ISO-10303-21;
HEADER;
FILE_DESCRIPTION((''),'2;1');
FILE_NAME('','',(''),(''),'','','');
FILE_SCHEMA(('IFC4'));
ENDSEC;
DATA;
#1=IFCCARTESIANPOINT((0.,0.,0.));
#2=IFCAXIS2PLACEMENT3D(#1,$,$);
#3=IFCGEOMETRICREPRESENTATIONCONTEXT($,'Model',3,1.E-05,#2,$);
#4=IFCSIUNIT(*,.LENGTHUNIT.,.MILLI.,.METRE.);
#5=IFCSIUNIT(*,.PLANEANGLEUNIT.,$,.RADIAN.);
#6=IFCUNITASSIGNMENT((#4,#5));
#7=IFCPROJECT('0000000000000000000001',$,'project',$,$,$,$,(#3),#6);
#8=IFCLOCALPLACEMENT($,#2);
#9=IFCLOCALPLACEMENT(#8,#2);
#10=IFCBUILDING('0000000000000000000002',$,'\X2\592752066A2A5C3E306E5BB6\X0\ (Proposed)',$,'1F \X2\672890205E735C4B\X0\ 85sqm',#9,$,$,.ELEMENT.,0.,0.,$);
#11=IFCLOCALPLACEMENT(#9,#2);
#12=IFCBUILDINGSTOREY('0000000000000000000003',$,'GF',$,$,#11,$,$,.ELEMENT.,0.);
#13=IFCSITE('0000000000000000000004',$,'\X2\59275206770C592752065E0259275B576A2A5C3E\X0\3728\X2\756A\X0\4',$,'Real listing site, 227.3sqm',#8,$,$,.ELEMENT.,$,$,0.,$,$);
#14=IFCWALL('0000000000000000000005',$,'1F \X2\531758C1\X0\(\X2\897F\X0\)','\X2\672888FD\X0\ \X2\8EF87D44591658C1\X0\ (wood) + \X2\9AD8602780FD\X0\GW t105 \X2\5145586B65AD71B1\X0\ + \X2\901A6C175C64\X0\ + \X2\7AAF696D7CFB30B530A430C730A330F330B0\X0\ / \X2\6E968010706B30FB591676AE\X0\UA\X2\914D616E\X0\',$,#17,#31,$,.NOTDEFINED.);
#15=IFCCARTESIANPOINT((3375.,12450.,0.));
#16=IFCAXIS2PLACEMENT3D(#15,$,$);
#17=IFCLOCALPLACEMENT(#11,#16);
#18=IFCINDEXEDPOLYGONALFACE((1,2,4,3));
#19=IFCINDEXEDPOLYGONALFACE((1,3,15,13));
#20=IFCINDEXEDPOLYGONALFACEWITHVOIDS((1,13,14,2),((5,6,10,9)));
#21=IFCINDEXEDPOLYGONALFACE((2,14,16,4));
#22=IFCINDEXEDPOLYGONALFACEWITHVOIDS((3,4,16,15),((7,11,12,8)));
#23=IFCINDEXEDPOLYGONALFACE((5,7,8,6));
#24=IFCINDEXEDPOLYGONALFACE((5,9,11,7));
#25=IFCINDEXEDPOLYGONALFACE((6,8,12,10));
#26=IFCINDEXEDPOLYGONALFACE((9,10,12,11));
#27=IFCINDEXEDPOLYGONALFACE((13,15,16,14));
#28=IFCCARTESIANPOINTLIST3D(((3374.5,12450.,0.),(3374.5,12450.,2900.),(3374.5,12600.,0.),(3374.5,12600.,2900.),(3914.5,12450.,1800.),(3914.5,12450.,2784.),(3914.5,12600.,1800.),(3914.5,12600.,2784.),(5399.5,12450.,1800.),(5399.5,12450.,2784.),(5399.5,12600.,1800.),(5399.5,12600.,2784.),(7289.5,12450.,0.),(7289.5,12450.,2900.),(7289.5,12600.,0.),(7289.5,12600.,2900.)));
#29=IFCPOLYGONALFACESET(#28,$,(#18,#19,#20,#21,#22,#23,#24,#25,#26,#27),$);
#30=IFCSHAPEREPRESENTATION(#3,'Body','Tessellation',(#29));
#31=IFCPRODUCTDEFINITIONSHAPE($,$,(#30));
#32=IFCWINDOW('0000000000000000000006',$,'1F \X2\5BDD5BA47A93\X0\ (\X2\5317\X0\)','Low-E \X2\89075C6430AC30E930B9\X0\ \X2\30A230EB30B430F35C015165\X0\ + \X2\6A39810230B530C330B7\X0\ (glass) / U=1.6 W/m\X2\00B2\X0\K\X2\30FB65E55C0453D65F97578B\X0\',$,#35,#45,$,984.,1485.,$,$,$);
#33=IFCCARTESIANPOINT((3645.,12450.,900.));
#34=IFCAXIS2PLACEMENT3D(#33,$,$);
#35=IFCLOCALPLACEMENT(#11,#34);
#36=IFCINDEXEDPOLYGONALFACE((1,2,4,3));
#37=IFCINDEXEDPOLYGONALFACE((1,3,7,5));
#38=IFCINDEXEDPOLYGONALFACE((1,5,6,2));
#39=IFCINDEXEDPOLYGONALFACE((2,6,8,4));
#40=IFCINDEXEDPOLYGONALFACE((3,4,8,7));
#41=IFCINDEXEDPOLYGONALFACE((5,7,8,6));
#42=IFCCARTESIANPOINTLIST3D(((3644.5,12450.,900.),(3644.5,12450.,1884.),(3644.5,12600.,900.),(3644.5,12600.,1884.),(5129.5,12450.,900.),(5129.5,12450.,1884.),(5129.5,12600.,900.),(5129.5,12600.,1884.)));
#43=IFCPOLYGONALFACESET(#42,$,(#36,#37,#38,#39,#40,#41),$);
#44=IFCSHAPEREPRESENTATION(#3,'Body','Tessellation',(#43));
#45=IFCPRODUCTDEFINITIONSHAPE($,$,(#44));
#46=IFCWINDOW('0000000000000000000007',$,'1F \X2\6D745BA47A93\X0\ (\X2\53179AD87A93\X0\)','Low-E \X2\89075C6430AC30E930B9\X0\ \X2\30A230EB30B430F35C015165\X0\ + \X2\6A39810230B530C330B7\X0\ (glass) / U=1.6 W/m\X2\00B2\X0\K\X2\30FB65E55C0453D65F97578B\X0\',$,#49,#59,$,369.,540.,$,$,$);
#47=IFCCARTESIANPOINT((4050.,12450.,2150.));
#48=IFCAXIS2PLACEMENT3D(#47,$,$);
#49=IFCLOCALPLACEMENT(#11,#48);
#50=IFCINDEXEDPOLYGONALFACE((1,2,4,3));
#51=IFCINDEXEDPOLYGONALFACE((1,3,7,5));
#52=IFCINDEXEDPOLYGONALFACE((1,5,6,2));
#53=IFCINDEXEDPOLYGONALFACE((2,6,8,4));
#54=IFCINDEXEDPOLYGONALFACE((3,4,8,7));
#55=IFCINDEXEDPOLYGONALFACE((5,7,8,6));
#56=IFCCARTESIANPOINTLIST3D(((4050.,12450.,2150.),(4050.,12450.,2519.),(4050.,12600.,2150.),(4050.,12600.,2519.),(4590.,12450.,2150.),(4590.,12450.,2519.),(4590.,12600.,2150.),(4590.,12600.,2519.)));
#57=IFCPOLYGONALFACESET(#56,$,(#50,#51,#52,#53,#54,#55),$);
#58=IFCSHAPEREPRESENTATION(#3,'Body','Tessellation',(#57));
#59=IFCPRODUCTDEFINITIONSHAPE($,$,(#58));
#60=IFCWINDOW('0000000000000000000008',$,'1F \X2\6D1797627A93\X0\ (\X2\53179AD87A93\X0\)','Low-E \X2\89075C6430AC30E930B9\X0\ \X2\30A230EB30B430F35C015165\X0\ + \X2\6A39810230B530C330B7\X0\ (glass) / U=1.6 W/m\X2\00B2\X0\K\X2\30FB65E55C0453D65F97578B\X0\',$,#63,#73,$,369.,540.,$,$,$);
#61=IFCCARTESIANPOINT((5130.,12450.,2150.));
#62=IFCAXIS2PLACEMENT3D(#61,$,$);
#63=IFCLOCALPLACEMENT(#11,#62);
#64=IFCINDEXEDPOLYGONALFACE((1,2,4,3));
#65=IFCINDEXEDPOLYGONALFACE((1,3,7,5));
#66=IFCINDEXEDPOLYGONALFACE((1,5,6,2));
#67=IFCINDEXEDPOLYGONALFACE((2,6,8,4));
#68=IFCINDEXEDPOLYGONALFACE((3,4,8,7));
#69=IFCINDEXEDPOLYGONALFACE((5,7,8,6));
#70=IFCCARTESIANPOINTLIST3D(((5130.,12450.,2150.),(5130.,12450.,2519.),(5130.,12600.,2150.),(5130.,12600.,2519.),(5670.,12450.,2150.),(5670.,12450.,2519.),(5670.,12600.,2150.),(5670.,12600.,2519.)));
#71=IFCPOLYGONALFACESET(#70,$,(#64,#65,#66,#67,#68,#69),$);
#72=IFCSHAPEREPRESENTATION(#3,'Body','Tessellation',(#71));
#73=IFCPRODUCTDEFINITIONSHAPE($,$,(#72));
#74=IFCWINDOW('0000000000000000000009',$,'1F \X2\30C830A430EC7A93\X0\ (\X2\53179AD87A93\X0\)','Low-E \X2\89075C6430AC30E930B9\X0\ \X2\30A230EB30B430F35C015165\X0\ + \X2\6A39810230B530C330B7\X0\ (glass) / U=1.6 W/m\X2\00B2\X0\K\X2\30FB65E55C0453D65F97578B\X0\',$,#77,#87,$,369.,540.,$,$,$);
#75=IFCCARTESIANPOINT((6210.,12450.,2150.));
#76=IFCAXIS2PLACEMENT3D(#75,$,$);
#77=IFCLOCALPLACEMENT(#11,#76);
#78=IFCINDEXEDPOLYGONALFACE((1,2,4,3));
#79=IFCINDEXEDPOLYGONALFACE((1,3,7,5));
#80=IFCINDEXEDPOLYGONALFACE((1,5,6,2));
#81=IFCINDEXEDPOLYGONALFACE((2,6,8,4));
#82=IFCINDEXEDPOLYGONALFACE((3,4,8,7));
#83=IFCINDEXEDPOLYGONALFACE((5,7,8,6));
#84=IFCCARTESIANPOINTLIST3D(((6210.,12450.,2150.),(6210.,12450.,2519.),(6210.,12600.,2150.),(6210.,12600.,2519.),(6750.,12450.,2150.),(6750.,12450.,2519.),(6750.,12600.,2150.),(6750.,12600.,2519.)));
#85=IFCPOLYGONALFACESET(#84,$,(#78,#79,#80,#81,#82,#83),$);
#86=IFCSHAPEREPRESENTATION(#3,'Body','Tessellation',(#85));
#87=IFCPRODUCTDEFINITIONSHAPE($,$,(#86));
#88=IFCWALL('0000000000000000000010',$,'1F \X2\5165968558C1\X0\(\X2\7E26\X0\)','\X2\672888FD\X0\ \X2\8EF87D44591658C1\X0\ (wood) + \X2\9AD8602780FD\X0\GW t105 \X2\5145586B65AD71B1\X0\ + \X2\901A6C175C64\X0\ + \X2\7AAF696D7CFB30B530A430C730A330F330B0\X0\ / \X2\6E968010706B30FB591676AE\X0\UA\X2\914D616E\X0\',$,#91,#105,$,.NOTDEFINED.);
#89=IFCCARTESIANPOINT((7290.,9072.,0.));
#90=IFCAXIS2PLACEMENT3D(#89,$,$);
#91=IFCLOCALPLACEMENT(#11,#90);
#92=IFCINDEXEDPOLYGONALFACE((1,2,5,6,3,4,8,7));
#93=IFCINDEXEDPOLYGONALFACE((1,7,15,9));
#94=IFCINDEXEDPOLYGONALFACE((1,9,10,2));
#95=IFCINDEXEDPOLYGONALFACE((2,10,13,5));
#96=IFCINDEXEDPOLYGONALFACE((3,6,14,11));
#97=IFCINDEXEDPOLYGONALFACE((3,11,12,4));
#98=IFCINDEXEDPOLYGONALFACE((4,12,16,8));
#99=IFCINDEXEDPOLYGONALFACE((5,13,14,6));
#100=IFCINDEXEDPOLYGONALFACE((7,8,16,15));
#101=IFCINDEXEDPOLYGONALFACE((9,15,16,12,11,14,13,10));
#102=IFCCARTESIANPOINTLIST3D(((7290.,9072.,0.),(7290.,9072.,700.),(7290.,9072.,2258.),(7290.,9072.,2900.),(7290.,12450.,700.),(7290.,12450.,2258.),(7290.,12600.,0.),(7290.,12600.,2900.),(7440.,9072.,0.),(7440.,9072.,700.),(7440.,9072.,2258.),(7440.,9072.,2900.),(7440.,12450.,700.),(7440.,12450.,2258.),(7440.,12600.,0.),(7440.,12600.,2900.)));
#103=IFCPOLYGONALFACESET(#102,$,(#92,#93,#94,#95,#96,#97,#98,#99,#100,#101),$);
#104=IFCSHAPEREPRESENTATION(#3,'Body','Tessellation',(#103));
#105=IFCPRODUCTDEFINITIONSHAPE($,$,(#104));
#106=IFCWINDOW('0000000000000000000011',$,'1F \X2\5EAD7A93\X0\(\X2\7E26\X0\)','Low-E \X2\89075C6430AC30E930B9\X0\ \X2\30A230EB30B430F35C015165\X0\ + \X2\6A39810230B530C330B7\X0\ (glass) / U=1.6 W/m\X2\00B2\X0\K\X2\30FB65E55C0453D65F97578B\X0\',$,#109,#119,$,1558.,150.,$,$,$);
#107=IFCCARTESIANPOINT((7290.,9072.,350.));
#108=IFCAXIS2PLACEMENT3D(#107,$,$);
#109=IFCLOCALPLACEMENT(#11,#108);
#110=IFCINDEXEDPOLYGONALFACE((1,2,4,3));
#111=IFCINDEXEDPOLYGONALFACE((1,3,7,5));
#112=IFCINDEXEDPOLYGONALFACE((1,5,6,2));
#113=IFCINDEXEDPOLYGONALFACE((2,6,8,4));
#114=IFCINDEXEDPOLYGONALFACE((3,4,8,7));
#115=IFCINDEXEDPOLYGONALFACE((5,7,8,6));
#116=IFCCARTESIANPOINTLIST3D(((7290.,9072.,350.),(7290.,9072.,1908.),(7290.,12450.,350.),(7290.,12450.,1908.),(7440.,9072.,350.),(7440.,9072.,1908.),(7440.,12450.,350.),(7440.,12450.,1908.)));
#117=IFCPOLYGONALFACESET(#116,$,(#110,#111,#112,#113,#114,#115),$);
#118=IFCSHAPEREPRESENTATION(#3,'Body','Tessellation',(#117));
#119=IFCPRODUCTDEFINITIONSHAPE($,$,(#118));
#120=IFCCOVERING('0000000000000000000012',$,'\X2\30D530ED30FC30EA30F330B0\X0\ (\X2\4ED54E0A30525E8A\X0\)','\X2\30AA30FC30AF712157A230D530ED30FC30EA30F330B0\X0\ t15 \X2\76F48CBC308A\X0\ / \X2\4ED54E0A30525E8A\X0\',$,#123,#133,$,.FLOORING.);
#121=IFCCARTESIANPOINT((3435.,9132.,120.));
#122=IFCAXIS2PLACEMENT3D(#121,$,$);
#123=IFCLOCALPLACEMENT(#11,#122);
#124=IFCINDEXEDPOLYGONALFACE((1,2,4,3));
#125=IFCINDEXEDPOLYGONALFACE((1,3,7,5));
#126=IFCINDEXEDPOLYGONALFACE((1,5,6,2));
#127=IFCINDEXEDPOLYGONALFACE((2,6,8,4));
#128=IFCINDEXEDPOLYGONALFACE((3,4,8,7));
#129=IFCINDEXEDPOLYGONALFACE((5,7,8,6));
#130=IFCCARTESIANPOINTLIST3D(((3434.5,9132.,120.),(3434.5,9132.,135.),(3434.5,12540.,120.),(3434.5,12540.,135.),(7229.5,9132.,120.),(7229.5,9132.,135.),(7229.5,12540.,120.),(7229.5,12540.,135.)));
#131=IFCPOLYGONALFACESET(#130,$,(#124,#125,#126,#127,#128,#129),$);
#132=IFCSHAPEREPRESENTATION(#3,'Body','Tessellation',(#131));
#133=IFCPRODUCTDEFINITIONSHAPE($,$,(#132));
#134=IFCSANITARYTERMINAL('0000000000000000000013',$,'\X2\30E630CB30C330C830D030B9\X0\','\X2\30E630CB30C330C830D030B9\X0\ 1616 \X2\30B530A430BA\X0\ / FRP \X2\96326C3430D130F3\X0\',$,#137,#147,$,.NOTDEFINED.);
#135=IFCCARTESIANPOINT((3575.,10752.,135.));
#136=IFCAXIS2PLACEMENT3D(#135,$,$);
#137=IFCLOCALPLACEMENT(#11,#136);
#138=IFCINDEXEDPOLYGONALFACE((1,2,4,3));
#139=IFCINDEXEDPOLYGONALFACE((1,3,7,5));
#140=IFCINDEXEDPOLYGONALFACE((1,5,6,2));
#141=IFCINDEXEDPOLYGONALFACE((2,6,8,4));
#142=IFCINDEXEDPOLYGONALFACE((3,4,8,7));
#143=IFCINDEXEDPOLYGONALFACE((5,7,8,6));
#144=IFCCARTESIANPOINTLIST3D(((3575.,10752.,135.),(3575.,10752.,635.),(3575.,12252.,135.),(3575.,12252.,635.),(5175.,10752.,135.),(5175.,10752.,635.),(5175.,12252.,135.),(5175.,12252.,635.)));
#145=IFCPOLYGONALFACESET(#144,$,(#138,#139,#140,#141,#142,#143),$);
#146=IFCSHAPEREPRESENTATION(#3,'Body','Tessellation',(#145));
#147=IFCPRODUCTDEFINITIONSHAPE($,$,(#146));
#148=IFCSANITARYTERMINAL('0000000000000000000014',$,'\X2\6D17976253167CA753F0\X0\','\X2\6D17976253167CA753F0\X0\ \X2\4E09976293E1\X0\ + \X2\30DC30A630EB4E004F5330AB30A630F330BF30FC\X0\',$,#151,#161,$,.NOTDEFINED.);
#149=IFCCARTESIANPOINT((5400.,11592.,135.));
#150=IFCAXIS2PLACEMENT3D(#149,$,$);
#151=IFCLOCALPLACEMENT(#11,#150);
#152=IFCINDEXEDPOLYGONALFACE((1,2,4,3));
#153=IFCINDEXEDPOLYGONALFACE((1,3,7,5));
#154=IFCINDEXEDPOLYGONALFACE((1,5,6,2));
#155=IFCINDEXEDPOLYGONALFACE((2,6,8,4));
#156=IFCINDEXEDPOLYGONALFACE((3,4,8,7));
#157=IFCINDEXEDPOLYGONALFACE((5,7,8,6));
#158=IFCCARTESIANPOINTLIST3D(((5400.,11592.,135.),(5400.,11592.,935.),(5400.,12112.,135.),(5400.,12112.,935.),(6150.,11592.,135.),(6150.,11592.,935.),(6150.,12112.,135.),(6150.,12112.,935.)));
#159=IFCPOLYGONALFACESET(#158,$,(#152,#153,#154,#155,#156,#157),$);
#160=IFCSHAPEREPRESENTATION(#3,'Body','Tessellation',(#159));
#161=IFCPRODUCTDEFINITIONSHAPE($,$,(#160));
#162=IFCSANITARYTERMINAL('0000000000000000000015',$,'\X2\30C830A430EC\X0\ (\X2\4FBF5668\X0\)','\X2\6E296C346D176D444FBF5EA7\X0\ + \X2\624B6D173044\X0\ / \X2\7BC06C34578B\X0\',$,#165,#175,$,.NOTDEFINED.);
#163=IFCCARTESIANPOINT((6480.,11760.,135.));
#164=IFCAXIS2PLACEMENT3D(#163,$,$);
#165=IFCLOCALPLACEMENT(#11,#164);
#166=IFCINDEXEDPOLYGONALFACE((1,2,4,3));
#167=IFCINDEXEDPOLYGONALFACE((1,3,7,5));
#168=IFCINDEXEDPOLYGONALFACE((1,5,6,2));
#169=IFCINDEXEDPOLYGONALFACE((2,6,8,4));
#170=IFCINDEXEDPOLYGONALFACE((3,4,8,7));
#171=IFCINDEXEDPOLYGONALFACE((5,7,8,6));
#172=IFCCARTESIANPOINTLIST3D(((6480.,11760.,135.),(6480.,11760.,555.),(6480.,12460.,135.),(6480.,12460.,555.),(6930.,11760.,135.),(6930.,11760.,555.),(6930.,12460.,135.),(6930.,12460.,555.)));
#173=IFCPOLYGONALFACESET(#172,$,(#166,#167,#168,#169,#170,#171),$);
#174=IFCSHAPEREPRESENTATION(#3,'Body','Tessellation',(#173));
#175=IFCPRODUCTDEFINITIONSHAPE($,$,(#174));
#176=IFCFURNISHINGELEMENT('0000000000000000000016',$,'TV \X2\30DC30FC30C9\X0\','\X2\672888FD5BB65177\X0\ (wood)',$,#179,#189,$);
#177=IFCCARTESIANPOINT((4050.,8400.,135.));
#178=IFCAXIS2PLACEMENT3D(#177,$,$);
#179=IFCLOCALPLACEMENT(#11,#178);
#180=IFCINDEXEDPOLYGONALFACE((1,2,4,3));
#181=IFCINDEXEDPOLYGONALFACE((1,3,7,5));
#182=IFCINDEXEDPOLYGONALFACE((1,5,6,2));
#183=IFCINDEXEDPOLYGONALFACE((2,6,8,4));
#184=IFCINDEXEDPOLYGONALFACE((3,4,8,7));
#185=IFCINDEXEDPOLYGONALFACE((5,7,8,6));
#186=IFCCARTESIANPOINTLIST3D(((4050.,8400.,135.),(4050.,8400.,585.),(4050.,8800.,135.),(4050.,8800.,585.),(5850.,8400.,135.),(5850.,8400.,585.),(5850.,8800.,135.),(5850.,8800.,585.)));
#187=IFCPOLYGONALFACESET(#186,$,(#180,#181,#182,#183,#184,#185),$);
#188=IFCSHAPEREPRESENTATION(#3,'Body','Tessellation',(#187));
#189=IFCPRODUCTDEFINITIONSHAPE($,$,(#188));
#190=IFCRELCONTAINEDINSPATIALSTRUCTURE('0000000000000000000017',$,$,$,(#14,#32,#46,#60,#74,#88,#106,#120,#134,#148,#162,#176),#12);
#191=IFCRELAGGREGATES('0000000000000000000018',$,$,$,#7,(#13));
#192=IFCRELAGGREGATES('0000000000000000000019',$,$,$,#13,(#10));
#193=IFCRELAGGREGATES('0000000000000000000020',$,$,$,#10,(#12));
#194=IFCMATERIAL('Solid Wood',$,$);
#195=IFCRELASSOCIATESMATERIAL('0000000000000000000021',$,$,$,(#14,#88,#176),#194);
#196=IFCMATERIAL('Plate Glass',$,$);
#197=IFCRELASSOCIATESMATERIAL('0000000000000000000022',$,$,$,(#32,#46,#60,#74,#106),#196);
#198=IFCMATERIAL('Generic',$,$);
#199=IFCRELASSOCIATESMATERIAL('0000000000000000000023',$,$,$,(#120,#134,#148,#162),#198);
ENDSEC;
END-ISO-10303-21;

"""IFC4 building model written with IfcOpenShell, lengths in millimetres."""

from ifc_helpers import new_model, si_unit, frame, frame_2d, origin, place, context, project, spatial, rectangle, extrude, material, element, fill, save


model = new_model("IFC4")

# Units and contexts
model_context = context("Model", 3, precision=1e-05, world=origin())
ifc_project = project(units=[si_unit("LENGTHUNIT", "METRE", prefix="MILLI"), si_unit("PLANEANGLEUNIT", "RADIAN")], contexts=[model_context])

# Site, building, storey
site_placement = place(None, origin())
site = spatial("IfcSite", under=ifc_project, at=site_placement, Name="大分県大分市大字横尾3728番4", ObjectType="Real listing site, 227.3sqm", CompositionType="ELEMENT", RefElevation=0.0)
building_placement = place(site_placement, origin())
building = spatial("IfcBuilding", under=site, at=building_placement, Name="大分横尾の家 (Proposed)", ObjectType="1F 木造平屋 85sqm", CompositionType="ELEMENT", ElevationOfRefHeight=0.0, ElevationOfTerrain=0.0)
storey_placement = place(building_placement, origin())
storey = spatial("IfcBuildingStorey", under=building, at=storey_placement, Name="GF", CompositionType="ELEMENT", Elevation=0.0)

# Shared definitions
ifc_material_1 = material(Name="Solid Wood")

# Wall, openings, windows
wall_1_placement = place(storey_placement, frame((3375.0, 12450.0, 0.0)))
wall_1 = element("IfcWall", 1, at=wall_1_placement, inside=storey, material=ifc_material_1, Name="1F 北壁(西)", Description="木製 軸組外壁 (wood) + 高性能GW t105 充填断熱 + 通気層 + 窯業系サイディング / 準耐火・外皮UA配慮", PredefinedType="NOTDEFINED", context=model_context, shape_type="SweptSolid", body=[
    extrude(rectangle(XDim=3915.0, YDim=150.0, at=frame_2d((1957.0, 75.0))), frame((3375.0, 12450.0, 0.0)), (0.0, 0.0, 1.0), 2900.0),
])
opening_1_placement = place(storey_placement, frame((3645.0, 12450.0, 900.0)))
opening_1 = element("IfcOpeningElement", 2, at=opening_1_placement, cuts=wall_1, PredefinedType="NOTDEFINED", context=model_context, shape_type="SweptSolid", body=[
    extrude(rectangle(XDim=1485.0, YDim=150.0, at=frame_2d((742.0, 75.0))), frame((3645.0, 12450.0, 900.0)), (0.0, 0.0, 1.0), 984.0),
])
opening_2_placement = place(storey_placement, frame((4050.0, 12450.0, 2150.0)))
opening_2 = element("IfcOpeningElement", 3, at=opening_2_placement, cuts=wall_1, PredefinedType="NOTDEFINED", context=model_context, shape_type="SweptSolid", body=[
    extrude(rectangle(XDim=540.0, YDim=150.0, at=frame_2d((270.0, 75.0))), frame((4050.0, 12450.0, 2150.0)), (0.0, 0.0, 1.0), 369.0),
])
opening_3_placement = place(storey_placement, frame((5130.0, 12450.0, 2150.0)))
opening_3 = element("IfcOpeningElement", 4, at=opening_3_placement, cuts=wall_1, PredefinedType="NOTDEFINED", context=model_context, shape_type="SweptSolid", body=[
    extrude(rectangle(XDim=540.0, YDim=150.0, at=frame_2d((270.0, 75.0))), frame((5130.0, 12450.0, 2150.0)), (0.0, 0.0, 1.0), 369.0),
])
opening_4_placement = place(storey_placement, frame((6210.0, 12450.0, 2150.0)))
opening_4 = element("IfcOpeningElement", 5, at=opening_4_placement, cuts=wall_1, PredefinedType="NOTDEFINED", context=model_context, shape_type="SweptSolid", body=[
    extrude(rectangle(XDim=540.0, YDim=150.0, at=frame_2d((270.0, 75.0))), frame((6210.0, 12450.0, 2150.0)), (0.0, 0.0, 1.0), 369.0),
])
ifc_material_2 = material(Name="Plate Glass")
window_1_placement = place(storey_placement, frame((3645.0, 12450.0, 900.0)))
window_1 = element("IfcWindow", 6, at=window_1_placement, inside=storey, material=ifc_material_2, Name="1F 寝室窓 (北)", Description="Low-E 複層ガラス アルゴン封入 + 樹脂サッシ (glass) / U=1.6 W/m²K・日射取得型", OverallHeight=984.0, OverallWidth=1485.0, context=model_context, shape_type="SweptSolid", body=[
    extrude(rectangle(XDim=1485.0, YDim=150.0, at=frame_2d((742.0, 75.0))), frame((3645.0, 12450.0, 900.0)), (0.0, 0.0, 1.0), 984.0),
])
fill(opening_1, window_1)
window_2_placement = place(storey_placement, frame((4050.0, 12450.0, 2150.0)))
window_2 = element("IfcWindow", 7, at=window_2_placement, inside=storey, material=ifc_material_2, Name="1F 浴室窓 (北高窓)", Description="Low-E 複層ガラス アルゴン封入 + 樹脂サッシ (glass) / U=1.6 W/m²K・日射取得型", OverallHeight=369.0, OverallWidth=540.0, context=model_context, shape_type="SweptSolid", body=[
    extrude(rectangle(XDim=540.0, YDim=150.0, at=frame_2d((270.0, 75.0))), frame((4050.0, 12450.0, 2150.0)), (0.0, 0.0, 1.0), 369.0),
])
fill(opening_2, window_2)
window_3_placement = place(storey_placement, frame((5130.0, 12450.0, 2150.0)))
window_3 = element("IfcWindow", 8, at=window_3_placement, inside=storey, material=ifc_material_2, Name="1F 洗面窓 (北高窓)", Description="Low-E 複層ガラス アルゴン封入 + 樹脂サッシ (glass) / U=1.6 W/m²K・日射取得型", OverallHeight=369.0, OverallWidth=540.0, context=model_context, shape_type="SweptSolid", body=[
    extrude(rectangle(XDim=540.0, YDim=150.0, at=frame_2d((270.0, 75.0))), frame((5130.0, 12450.0, 2150.0)), (0.0, 0.0, 1.0), 369.0),
])
fill(opening_3, window_3)
window_4_placement = place(storey_placement, frame((6210.0, 12450.0, 2150.0)))
window_4 = element("IfcWindow", 9, at=window_4_placement, inside=storey, material=ifc_material_2, Name="1F トイレ窓 (北高窓)", Description="Low-E 複層ガラス アルゴン封入 + 樹脂サッシ (glass) / U=1.6 W/m²K・日射取得型", OverallHeight=369.0, OverallWidth=540.0, context=model_context, shape_type="SweptSolid", body=[
    extrude(rectangle(XDim=540.0, YDim=150.0, at=frame_2d((270.0, 75.0))), frame((6210.0, 12450.0, 2150.0)), (0.0, 0.0, 1.0), 369.0),
])
fill(opening_4, window_4)

# Wall, opening, window
wall_2_placement = place(storey_placement, frame((7290.0, 9072.0, 0.0)))
wall_2 = element("IfcWall", 10, at=wall_2_placement, inside=storey, material=ifc_material_1, Name="1F 入隅壁(縦)", Description="木製 軸組外壁 (wood) + 高性能GW t105 充填断熱 + 通気層 + 窯業系サイディング / 準耐火・外皮UA配慮", PredefinedType="NOTDEFINED", context=model_context, shape_type="SweptSolid", body=[
    extrude(rectangle(XDim=150.0, YDim=3528.0, at=frame_2d((75.0, 1764.0))), frame((7290.0, 9072.0, 0.0)), (0.0, 0.0, 1.0), 2900.0),
])
opening_5_placement = place(storey_placement, frame((7290.0, 9072.0, 350.0)))
opening_5 = element("IfcOpeningElement", 11, at=opening_5_placement, cuts=wall_2, PredefinedType="NOTDEFINED", context=model_context, shape_type="SweptSolid", body=[
    extrude(rectangle(XDim=150.0, YDim=3378.0, at=frame_2d((75.0, 1689.0))), frame((7290.0, 9072.0, 350.0)), (0.0, 0.0, 1.0), 1558.0),
])
window_5_placement = place(storey_placement, frame((7290.0, 9072.0, 350.0)))
window_5 = element("IfcWindow", 12, at=window_5_placement, inside=storey, material=ifc_material_2, Name="1F 庭窓(縦)", Description="Low-E 複層ガラス アルゴン封入 + 樹脂サッシ (glass) / U=1.6 W/m²K・日射取得型", OverallHeight=1558.0, OverallWidth=150.0, context=model_context, shape_type="SweptSolid", body=[
    extrude(rectangle(XDim=150.0, YDim=3378.0, at=frame_2d((75.0, 1689.0))), frame((7290.0, 9072.0, 350.0)), (0.0, 0.0, 1.0), 1558.0),
])
fill(opening_5, window_5)

# Covering
ifc_material_3 = material(Name="Generic")
covering_placement = place(storey_placement, frame((3435.0, 9132.0, 120.0)))
element("IfcCovering", 13, at=covering_placement, inside=storey, material=ifc_material_3, Name="フローリング (仕上げ床)", Description="オーク無垢フローリング t15 直貼り / 仕上げ床", PredefinedType="FLOORING", context=model_context, shape_type="SweptSolid", body=[
    extrude(rectangle(XDim=3795.0, YDim=3408.0, at=frame_2d((1897.0, 1704.0))), frame((3435.0, 9132.0, 120.0)), (0.0, 0.0, 1.0), 15.0),
])

# Sanitary terminals
sanitary_terminal_1_placement = place(storey_placement, frame((3575.0, 10752.0, 135.0)))
element("IfcSanitaryTerminal", 14, at=sanitary_terminal_1_placement, inside=storey, material=ifc_material_3, Name="ユニットバス", Description="ユニットバス 1616 サイズ / FRP 防水パン", PredefinedType="NOTDEFINED", context=model_context, shape_type="SweptSolid", body=[
    extrude(rectangle(XDim=1600.0, YDim=1500.0, at=frame_2d((800.0, 750.0))), frame((3575.0, 10752.0, 135.0)), (0.0, 0.0, 1.0), 500.0),
])
sanitary_terminal_2_placement = place(storey_placement, frame((5400.0, 11592.0, 135.0)))
element("IfcSanitaryTerminal", 15, at=sanitary_terminal_2_placement, inside=storey, material=ifc_material_3, Name="洗面化粧台", Description="洗面化粧台 三面鏡 + ボウル一体カウンター", PredefinedType="NOTDEFINED", context=model_context, shape_type="SweptSolid", body=[
    extrude(rectangle(XDim=750.0, YDim=520.0, at=frame_2d((375.0, 260.0))), frame((5400.0, 11592.0, 135.0)), (0.0, 0.0, 1.0), 800.0),
])
sanitary_terminal_3_placement = place(storey_placement, frame((6480.0, 11760.0, 135.0)))
element("IfcSanitaryTerminal", 16, at=sanitary_terminal_3_placement, inside=storey, material=ifc_material_3, Name="トイレ (便器)", Description="温水洗浄便座 + 手洗い / 節水型", PredefinedType="NOTDEFINED", context=model_context, shape_type="SweptSolid", body=[
    extrude(rectangle(XDim=450.0, YDim=700.0, at=frame_2d((225.0, 350.0))), frame((6480.0, 11760.0, 135.0)), (0.0, 0.0, 1.0), 420.0),
])

# Furnishing element
furnishing_placement = place(storey_placement, frame((4050.0, 8400.0, 135.0)))
element("IfcFurnishingElement", 17, at=furnishing_placement, inside=storey, material=ifc_material_1, Name="TV ボード", Description="木製家具 (wood)", context=model_context, shape_type="SweptSolid", body=[
    extrude(rectangle(XDim=1800.0, YDim=400.0, at=frame_2d((900.0, 200.0))), frame((4050.0, 8400.0, 135.0)), (0.0, 0.0, 1.0), 450.0),
])

save(model, "model.ifc")
